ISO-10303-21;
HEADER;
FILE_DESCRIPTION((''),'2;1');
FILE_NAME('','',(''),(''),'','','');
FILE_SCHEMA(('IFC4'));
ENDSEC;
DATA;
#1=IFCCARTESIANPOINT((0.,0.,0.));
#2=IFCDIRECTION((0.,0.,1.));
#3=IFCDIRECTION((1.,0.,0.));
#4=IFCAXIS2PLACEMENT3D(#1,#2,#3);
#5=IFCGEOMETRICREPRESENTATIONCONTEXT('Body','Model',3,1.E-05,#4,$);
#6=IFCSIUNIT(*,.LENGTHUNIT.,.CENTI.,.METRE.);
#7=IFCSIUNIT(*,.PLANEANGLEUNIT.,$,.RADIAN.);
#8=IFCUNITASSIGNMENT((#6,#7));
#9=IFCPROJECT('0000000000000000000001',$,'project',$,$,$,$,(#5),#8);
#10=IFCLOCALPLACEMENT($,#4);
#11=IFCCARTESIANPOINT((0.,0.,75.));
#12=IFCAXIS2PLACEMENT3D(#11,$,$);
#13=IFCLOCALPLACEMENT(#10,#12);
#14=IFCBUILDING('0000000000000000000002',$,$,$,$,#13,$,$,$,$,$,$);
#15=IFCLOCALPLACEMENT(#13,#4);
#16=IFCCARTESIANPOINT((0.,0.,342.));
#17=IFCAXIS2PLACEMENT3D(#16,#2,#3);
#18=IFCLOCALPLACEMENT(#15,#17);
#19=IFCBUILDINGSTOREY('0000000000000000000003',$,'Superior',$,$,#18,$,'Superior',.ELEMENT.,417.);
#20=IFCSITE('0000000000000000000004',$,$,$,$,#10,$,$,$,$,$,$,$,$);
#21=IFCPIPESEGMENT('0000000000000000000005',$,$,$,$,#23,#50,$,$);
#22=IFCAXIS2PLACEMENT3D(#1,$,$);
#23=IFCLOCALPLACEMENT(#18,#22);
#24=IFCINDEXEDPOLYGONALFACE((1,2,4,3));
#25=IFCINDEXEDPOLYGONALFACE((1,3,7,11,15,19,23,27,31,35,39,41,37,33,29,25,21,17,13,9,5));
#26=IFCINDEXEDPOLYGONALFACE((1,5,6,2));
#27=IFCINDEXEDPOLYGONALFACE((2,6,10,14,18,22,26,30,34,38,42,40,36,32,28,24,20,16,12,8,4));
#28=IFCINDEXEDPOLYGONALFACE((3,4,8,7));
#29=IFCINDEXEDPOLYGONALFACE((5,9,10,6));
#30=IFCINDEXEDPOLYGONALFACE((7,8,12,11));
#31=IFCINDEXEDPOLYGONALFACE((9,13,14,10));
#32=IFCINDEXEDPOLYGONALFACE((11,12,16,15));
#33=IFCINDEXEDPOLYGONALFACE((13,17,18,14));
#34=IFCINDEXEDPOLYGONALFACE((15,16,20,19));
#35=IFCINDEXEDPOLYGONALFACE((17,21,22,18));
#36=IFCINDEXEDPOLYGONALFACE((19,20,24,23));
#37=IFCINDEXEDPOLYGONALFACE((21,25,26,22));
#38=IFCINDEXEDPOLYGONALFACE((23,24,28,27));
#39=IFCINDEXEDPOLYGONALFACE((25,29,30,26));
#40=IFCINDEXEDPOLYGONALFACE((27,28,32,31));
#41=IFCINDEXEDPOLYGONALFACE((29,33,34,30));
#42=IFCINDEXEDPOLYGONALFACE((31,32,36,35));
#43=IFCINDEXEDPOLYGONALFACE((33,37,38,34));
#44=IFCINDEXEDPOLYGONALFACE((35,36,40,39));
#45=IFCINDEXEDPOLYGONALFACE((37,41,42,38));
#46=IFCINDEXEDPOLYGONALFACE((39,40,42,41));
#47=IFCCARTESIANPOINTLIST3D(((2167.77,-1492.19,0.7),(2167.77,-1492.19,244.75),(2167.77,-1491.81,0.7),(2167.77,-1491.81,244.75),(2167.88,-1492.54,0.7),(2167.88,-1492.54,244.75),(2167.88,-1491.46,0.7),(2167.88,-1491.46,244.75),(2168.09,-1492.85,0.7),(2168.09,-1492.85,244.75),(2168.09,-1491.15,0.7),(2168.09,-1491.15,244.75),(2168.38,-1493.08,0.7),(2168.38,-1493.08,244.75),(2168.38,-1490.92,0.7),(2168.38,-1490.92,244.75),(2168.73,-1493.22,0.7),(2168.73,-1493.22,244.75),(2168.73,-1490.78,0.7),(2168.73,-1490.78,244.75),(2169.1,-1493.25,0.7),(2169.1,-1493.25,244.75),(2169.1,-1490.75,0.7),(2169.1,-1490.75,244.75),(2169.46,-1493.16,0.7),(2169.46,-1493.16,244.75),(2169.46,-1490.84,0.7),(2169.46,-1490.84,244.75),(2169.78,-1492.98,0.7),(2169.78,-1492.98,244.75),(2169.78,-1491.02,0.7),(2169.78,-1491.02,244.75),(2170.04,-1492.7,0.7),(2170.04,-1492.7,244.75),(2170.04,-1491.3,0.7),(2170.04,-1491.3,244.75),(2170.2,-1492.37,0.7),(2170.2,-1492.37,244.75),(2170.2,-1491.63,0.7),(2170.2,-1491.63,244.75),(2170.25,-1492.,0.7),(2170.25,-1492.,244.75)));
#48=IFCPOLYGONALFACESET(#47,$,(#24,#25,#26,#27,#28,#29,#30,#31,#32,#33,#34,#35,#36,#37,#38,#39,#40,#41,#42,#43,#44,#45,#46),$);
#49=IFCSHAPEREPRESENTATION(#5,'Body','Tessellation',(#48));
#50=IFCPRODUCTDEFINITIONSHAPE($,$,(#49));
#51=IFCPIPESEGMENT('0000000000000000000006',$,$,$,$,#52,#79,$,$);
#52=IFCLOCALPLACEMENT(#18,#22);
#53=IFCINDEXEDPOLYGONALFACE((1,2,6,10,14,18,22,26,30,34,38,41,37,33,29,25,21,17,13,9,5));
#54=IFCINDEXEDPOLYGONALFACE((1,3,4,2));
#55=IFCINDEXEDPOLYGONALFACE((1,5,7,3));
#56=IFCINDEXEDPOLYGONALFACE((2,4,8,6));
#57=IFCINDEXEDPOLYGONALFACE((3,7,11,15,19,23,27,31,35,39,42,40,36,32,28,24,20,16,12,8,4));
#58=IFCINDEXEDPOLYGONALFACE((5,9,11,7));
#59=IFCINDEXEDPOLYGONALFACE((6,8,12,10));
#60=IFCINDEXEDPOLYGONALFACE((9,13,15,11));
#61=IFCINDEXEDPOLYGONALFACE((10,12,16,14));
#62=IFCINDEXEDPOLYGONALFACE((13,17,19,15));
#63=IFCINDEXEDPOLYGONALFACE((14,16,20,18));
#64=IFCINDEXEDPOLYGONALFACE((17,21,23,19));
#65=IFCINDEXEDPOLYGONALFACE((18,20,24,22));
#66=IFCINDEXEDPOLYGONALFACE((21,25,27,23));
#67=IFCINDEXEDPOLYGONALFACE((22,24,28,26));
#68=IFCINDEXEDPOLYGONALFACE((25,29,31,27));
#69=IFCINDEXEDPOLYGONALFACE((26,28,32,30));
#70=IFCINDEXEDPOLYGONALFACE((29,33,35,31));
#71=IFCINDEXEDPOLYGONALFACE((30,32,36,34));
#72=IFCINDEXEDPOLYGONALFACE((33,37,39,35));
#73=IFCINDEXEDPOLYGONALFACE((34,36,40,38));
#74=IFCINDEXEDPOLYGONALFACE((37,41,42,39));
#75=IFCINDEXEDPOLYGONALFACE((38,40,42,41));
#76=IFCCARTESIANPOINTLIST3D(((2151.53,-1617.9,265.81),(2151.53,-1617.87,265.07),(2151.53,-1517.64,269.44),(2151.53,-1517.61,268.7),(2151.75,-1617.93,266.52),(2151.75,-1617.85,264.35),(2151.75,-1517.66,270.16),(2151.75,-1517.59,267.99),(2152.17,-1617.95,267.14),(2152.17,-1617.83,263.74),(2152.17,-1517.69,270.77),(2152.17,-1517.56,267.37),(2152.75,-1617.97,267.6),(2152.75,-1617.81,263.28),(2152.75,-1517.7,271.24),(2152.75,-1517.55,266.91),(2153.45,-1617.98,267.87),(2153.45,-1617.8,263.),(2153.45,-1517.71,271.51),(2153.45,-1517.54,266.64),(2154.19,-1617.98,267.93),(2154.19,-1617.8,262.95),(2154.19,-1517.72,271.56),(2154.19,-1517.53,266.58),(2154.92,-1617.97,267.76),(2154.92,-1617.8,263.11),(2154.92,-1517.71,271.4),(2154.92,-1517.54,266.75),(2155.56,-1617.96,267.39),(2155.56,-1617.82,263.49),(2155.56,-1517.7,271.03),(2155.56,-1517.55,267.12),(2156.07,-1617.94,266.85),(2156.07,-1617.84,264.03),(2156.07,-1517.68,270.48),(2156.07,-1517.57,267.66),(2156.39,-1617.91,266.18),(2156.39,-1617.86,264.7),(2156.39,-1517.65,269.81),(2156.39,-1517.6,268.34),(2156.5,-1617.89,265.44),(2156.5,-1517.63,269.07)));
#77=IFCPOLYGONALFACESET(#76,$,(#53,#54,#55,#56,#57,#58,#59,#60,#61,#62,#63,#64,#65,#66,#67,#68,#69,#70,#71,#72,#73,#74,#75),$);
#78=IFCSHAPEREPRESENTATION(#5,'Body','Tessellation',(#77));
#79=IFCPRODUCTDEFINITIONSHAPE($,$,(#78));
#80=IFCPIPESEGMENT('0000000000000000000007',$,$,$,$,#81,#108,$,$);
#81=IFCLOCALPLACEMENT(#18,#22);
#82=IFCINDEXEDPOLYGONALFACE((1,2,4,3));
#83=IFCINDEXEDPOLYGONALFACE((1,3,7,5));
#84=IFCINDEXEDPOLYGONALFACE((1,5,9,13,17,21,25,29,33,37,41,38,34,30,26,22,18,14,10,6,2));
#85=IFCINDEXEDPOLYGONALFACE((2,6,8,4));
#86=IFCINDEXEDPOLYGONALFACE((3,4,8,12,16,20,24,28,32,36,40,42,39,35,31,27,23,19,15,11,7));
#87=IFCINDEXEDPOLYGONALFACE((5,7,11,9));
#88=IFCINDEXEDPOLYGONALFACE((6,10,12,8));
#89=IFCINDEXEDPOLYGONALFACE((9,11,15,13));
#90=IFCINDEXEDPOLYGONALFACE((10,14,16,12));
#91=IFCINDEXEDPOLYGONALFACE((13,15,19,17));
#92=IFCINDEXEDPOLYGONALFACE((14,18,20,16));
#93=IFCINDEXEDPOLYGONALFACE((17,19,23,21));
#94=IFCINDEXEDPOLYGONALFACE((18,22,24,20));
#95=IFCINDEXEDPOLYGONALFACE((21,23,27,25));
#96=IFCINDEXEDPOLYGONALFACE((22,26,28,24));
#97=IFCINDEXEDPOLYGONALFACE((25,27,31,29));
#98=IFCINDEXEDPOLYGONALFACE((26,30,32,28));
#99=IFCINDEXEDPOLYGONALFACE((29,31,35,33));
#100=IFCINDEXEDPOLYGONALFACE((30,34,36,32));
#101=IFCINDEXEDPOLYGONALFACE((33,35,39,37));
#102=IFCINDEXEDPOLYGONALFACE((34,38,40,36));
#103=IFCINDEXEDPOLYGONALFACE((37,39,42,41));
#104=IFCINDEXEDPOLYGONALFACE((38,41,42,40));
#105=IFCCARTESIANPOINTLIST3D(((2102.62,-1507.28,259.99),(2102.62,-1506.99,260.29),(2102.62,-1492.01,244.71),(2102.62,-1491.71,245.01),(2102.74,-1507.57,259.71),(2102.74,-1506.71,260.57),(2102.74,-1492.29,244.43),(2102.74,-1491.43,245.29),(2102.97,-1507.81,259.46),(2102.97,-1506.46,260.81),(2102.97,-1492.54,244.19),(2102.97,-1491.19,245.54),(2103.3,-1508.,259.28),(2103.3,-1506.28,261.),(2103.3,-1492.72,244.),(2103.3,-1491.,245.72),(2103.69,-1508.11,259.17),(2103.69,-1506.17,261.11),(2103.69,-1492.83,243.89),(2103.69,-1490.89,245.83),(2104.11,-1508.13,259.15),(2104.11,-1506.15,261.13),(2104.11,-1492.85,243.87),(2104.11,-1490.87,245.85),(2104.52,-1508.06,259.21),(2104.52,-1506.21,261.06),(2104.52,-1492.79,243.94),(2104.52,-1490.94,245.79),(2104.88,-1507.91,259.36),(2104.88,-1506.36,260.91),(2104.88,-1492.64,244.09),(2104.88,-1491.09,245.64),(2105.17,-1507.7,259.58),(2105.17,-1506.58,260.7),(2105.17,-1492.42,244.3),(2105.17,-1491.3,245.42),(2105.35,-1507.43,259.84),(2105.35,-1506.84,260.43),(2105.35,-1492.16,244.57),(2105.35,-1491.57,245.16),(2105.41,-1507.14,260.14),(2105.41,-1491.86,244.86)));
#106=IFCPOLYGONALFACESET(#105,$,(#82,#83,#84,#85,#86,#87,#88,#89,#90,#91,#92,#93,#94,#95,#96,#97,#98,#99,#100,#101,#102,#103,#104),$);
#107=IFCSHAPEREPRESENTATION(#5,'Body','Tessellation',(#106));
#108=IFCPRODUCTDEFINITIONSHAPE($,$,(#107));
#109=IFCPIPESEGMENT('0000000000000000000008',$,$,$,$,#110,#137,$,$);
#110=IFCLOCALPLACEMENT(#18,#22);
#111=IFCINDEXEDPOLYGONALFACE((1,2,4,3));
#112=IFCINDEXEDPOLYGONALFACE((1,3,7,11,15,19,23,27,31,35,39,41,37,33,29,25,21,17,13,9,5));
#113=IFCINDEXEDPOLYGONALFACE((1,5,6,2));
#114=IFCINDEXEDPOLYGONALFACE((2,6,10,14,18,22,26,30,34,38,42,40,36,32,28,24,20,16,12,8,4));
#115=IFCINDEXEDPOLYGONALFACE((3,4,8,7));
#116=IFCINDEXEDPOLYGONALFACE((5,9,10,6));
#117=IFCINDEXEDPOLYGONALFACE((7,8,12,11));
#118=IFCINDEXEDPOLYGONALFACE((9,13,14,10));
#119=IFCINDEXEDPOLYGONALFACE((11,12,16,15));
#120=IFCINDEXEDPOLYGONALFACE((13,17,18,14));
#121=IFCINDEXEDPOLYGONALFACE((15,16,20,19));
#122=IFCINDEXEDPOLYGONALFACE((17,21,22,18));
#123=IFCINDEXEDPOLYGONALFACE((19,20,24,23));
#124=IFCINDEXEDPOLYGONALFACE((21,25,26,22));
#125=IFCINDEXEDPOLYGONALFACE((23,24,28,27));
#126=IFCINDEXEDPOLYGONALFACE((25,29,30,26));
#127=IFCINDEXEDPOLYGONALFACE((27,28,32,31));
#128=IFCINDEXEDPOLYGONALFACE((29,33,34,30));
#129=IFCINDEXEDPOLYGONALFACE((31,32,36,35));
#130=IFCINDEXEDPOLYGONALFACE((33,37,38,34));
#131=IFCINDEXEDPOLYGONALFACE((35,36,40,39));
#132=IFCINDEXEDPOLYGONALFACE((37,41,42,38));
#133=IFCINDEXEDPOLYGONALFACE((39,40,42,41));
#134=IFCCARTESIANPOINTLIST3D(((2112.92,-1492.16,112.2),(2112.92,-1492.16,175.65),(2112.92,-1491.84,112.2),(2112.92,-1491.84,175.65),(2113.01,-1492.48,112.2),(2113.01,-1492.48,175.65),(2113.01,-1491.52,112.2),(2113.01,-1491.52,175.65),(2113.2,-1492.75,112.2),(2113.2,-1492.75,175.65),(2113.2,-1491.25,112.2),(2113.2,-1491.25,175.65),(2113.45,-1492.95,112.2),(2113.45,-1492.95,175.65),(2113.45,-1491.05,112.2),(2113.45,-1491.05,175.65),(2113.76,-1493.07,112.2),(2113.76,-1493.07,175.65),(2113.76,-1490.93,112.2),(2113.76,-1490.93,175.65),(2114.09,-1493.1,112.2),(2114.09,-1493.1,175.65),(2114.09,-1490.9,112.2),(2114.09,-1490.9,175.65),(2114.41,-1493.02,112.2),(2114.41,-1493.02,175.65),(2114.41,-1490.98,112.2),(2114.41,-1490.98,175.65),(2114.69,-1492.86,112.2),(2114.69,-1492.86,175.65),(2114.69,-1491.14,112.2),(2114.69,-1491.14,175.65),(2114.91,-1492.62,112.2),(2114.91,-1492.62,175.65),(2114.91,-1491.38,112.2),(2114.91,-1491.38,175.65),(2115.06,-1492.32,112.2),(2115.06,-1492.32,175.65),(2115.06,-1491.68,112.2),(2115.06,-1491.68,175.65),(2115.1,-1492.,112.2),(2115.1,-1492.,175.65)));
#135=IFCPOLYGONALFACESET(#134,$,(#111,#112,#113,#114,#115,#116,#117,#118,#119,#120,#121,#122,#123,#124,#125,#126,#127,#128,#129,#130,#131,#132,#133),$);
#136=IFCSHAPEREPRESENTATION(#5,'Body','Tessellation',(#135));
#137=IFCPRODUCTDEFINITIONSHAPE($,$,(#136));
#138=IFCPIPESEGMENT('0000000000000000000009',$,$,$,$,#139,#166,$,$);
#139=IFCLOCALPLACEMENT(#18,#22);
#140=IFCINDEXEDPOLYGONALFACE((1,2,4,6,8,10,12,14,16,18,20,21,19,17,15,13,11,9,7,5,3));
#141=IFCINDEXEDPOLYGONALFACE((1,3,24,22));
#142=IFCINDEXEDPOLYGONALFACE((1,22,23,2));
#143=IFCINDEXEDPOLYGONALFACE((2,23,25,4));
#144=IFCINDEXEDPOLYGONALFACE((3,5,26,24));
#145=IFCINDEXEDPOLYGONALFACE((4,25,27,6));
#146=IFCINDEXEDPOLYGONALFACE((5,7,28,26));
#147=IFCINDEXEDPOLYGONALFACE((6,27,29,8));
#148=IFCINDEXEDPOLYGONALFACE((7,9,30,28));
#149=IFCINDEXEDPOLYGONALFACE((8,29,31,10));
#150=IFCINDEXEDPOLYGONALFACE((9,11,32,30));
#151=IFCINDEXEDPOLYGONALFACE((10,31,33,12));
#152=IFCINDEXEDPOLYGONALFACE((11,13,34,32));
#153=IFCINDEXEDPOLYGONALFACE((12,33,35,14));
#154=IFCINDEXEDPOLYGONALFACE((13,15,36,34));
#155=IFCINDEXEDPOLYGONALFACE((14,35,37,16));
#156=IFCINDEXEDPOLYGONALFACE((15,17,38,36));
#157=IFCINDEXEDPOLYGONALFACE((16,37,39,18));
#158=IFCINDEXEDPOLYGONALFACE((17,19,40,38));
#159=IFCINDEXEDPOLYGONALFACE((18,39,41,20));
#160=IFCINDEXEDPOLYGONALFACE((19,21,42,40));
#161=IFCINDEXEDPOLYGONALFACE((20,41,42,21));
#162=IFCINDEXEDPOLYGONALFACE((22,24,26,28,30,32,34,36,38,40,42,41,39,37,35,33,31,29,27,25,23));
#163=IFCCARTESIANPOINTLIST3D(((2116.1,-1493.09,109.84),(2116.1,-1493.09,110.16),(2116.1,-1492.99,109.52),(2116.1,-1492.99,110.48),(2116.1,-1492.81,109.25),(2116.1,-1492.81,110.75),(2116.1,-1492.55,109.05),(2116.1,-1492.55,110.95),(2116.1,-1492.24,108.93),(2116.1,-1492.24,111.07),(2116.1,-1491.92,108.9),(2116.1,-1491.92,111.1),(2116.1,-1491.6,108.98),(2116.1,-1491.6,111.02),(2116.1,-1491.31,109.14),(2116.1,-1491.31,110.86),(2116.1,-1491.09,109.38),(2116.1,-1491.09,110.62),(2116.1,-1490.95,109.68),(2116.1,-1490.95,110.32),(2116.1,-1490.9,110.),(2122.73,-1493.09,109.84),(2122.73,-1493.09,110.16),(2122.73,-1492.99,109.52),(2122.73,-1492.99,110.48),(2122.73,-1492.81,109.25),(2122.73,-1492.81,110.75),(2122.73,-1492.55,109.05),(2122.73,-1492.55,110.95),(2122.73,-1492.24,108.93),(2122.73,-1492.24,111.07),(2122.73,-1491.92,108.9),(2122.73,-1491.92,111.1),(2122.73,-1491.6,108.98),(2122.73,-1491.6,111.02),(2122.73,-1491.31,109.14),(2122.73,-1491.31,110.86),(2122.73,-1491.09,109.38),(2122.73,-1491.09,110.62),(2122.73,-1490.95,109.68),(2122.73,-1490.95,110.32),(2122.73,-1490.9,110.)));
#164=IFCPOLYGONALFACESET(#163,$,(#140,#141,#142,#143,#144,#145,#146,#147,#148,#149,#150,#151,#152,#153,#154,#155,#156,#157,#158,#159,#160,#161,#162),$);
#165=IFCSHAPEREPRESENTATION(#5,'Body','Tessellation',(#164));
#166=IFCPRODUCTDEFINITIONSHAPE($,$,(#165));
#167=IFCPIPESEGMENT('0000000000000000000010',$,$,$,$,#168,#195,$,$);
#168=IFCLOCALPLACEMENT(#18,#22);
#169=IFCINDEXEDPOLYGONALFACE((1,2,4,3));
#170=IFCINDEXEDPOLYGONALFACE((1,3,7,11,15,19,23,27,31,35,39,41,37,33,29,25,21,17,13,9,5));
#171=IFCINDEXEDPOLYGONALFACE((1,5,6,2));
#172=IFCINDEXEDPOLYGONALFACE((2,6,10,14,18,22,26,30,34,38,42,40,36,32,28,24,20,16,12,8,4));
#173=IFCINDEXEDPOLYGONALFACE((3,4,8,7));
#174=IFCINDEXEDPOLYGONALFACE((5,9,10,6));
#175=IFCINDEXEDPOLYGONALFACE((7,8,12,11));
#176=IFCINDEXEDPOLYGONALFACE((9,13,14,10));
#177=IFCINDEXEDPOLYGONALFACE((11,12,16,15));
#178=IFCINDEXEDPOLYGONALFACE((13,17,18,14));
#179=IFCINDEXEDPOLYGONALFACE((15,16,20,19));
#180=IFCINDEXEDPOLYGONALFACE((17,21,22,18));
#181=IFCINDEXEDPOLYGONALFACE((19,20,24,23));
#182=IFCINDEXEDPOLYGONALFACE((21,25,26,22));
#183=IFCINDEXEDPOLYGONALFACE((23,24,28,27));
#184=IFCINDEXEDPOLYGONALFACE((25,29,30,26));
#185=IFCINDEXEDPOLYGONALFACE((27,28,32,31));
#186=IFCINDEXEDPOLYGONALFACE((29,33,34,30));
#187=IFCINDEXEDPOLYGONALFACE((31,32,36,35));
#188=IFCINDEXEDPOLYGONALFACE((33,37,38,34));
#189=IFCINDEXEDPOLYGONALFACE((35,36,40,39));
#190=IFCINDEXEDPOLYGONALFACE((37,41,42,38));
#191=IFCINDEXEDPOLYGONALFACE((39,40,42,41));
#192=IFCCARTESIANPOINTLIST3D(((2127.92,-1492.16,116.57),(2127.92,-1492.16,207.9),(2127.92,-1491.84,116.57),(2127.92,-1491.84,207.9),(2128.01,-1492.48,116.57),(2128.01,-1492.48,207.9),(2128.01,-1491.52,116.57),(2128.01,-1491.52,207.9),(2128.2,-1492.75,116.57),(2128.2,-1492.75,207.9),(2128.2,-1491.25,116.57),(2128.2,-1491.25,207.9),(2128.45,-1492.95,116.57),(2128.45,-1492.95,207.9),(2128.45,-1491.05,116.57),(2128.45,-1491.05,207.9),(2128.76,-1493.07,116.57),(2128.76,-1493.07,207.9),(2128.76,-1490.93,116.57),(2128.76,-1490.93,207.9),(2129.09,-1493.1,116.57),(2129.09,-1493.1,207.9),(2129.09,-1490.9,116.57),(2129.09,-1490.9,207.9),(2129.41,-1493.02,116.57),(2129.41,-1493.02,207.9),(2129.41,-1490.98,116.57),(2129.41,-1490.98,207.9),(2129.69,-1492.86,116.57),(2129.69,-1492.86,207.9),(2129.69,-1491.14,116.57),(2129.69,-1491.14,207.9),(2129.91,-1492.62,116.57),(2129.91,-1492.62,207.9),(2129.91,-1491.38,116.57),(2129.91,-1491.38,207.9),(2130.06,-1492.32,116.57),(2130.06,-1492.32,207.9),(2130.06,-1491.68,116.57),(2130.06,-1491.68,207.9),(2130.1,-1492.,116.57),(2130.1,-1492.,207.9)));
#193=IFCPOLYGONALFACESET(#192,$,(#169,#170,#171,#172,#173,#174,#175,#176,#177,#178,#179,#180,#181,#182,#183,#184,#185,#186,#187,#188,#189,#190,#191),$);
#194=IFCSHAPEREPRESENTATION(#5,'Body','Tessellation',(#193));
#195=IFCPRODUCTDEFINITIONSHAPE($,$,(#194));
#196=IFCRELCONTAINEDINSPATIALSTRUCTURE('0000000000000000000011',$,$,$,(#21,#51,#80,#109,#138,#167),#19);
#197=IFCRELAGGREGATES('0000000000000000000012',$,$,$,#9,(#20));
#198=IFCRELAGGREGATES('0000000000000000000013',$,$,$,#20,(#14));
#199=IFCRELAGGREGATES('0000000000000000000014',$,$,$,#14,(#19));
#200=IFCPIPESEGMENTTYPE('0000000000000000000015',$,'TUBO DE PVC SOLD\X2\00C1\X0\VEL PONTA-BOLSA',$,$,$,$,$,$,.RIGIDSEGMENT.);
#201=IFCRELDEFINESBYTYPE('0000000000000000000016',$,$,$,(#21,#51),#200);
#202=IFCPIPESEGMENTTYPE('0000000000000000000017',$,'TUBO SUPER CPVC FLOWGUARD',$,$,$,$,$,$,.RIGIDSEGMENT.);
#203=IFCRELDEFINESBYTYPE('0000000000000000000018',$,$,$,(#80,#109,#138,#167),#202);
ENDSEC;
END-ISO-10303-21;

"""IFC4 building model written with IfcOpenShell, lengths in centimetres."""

from ifc_helpers import new_model, si_unit, frame, origin_with_axes, origin_2d_with_axis, place, context, project, spatial, circle, extrude, type_object, element, save


model = new_model("IFC4")

# Units and contexts
model_context = context("Model", 3, precision=1e-05, world=origin_with_axes(), identifier="Body")
ifc_project = project(units=[si_unit("LENGTHUNIT", "METRE", prefix="CENTI"), si_unit("PLANEANGLEUNIT", "RADIAN")], contexts=[model_context])

# Site, building, storey
site_placement = place(None, origin_with_axes())
site = spatial("IfcSite", under=ifc_project, at=site_placement)
building_placement = place(site_placement, frame((0.0, 0.0, 75.0)))
building = spatial("IfcBuilding", under=site, at=building_placement)
placement = place(building_placement, origin_with_axes())
storey_placement = place(placement, frame((0.0, 0.0, 342.0), z_axis=(0.0, 0.0, 1.0), x_axis=(1.0, 0.0, 0.0)))
storey = spatial("IfcBuildingStorey", under=building, at=storey_placement, Name="Superior", LongName="Superior", CompositionType="ELEMENT", Elevation=417.0)

# Pipe segments
pipe_segment_type_1 = type_object("IfcPipeSegmentType", Name="TUBO DE PVC SOLDÁVEL PONTA-BOLSA", PredefinedType="RIGIDSEGMENT")
pipe_segment_1_placement = place(storey_placement, frame((2169.0, -1492.0, 244.75), z_axis=(0.0, 0.0, 1.0), x_axis=(1.0, 0.0, 0.0)))
element("IfcPipeSegment", 1, at=pipe_segment_1_placement, inside=storey, type_object=pipe_segment_type_1, context=model_context, shape_type="SolidModel", body=[
    extrude(circle(Radius=1.25, at=origin_2d_with_axis()), frame((0.0, 0.0, -244.05), z_axis=(0.0, 0.0, 1.0), x_axis=(1.0, 0.0, 0.0)), (0.0, 0.0, 1.0), 244.05),
])
pipe_segment_2_placement = place(storey_placement, frame((2154.0, -1567.76, 271.57), z_axis=(0.0, 0.0, 1.0), x_axis=(1.0, 0.0, 0.0)))
element("IfcPipeSegment", 2, at=pipe_segment_2_placement, inside=storey, type_object=pipe_segment_type_1, context=model_context, shape_type="SolidModel", body=[
    extrude(circle(Radius=2.5, at=origin_2d_with_axis()), frame((0.0, -50.13, -6.13), z_axis=(0.0, 0.999344, 0.036214), x_axis=(1.0, 0.0, 0.0)), (0.0, 0.0, 1.0), 100.33),
])
pipe_segment_type_2 = type_object("IfcPipeSegmentType", Name="TUBO SUPER CPVC FLOWGUARD", PredefinedType="RIGIDSEGMENT")
pipe_segment_3_placement = place(storey_placement, frame((2104.0, -1499.5, 261.13), z_axis=(0.0, 0.0, 1.0), x_axis=(1.0, 0.0, 0.0)))
element("IfcPipeSegment", 3, at=pipe_segment_3_placement, inside=storey, type_object=pipe_segment_type_2, context=model_context, shape_type="SolidModel", body=[
    extrude(circle(Radius=1.41, at=origin_2d_with_axis()), frame((0.0, -7.64, -0.99), z_axis=(0.0, 0.707107, -0.707107), x_axis=(1.0, 0.0, 0.0)), (0.0, 0.0, 1.0), 21.6),
])
pipe_segment_4_placement = place(storey_placement, frame((2114.0, -1492.0, 175.65), z_axis=(0.0, 0.0, 1.0), x_axis=(1.0, 0.0, 0.0)))
element("IfcPipeSegment", 4, at=pipe_segment_4_placement, inside=storey, type_object=pipe_segment_type_2, context=model_context, shape_type="SolidModel", body=[
    extrude(circle(Radius=1.1, at=origin_2d_with_axis()), frame((0.0, 0.0, 0.0), z_axis=(0.0, 0.0, -1.0), x_axis=(1.0, 0.0, 0.0)), (0.0, 0.0, 1.0), 63.45),
])
pipe_segment_5_placement = place(storey_placement, frame((2119.42, -1492.0, 111.1), z_axis=(0.0, 0.0, 1.0), x_axis=(1.0, 0.0, 0.0)))
element("IfcPipeSegment", 5, at=pipe_segment_5_placement, inside=storey, type_object=pipe_segment_type_2, context=model_context, shape_type="SolidModel", body=[
    extrude(circle(Radius=1.1, at=origin_2d_with_axis()), frame((-3.32, 0.0, -1.1), z_axis=(1.0, 0.0, 0.0), x_axis=(0.0, 1.0, 0.0)), (0.0, 0.0, 1.0), 6.63),
])
pipe_segment_6_placement = place(storey_placement, frame((2129.0, -1492.0, 207.9), z_axis=(0.0, 0.0, 1.0), x_axis=(1.0, 0.0, 0.0)))
element("IfcPipeSegment", 6, at=pipe_segment_6_placement, inside=storey, type_object=pipe_segment_type_2, context=model_context, shape_type="SolidModel", body=[
    extrude(circle(Radius=1.1, at=origin_2d_with_axis()), frame((0.0, 0.0, -91.33), z_axis=(0.0, 0.0, 1.0), x_axis=(1.0, 0.0, 0.0)), (0.0, 0.0, 1.0), 91.33),
])

save(model, "model.ifc")
